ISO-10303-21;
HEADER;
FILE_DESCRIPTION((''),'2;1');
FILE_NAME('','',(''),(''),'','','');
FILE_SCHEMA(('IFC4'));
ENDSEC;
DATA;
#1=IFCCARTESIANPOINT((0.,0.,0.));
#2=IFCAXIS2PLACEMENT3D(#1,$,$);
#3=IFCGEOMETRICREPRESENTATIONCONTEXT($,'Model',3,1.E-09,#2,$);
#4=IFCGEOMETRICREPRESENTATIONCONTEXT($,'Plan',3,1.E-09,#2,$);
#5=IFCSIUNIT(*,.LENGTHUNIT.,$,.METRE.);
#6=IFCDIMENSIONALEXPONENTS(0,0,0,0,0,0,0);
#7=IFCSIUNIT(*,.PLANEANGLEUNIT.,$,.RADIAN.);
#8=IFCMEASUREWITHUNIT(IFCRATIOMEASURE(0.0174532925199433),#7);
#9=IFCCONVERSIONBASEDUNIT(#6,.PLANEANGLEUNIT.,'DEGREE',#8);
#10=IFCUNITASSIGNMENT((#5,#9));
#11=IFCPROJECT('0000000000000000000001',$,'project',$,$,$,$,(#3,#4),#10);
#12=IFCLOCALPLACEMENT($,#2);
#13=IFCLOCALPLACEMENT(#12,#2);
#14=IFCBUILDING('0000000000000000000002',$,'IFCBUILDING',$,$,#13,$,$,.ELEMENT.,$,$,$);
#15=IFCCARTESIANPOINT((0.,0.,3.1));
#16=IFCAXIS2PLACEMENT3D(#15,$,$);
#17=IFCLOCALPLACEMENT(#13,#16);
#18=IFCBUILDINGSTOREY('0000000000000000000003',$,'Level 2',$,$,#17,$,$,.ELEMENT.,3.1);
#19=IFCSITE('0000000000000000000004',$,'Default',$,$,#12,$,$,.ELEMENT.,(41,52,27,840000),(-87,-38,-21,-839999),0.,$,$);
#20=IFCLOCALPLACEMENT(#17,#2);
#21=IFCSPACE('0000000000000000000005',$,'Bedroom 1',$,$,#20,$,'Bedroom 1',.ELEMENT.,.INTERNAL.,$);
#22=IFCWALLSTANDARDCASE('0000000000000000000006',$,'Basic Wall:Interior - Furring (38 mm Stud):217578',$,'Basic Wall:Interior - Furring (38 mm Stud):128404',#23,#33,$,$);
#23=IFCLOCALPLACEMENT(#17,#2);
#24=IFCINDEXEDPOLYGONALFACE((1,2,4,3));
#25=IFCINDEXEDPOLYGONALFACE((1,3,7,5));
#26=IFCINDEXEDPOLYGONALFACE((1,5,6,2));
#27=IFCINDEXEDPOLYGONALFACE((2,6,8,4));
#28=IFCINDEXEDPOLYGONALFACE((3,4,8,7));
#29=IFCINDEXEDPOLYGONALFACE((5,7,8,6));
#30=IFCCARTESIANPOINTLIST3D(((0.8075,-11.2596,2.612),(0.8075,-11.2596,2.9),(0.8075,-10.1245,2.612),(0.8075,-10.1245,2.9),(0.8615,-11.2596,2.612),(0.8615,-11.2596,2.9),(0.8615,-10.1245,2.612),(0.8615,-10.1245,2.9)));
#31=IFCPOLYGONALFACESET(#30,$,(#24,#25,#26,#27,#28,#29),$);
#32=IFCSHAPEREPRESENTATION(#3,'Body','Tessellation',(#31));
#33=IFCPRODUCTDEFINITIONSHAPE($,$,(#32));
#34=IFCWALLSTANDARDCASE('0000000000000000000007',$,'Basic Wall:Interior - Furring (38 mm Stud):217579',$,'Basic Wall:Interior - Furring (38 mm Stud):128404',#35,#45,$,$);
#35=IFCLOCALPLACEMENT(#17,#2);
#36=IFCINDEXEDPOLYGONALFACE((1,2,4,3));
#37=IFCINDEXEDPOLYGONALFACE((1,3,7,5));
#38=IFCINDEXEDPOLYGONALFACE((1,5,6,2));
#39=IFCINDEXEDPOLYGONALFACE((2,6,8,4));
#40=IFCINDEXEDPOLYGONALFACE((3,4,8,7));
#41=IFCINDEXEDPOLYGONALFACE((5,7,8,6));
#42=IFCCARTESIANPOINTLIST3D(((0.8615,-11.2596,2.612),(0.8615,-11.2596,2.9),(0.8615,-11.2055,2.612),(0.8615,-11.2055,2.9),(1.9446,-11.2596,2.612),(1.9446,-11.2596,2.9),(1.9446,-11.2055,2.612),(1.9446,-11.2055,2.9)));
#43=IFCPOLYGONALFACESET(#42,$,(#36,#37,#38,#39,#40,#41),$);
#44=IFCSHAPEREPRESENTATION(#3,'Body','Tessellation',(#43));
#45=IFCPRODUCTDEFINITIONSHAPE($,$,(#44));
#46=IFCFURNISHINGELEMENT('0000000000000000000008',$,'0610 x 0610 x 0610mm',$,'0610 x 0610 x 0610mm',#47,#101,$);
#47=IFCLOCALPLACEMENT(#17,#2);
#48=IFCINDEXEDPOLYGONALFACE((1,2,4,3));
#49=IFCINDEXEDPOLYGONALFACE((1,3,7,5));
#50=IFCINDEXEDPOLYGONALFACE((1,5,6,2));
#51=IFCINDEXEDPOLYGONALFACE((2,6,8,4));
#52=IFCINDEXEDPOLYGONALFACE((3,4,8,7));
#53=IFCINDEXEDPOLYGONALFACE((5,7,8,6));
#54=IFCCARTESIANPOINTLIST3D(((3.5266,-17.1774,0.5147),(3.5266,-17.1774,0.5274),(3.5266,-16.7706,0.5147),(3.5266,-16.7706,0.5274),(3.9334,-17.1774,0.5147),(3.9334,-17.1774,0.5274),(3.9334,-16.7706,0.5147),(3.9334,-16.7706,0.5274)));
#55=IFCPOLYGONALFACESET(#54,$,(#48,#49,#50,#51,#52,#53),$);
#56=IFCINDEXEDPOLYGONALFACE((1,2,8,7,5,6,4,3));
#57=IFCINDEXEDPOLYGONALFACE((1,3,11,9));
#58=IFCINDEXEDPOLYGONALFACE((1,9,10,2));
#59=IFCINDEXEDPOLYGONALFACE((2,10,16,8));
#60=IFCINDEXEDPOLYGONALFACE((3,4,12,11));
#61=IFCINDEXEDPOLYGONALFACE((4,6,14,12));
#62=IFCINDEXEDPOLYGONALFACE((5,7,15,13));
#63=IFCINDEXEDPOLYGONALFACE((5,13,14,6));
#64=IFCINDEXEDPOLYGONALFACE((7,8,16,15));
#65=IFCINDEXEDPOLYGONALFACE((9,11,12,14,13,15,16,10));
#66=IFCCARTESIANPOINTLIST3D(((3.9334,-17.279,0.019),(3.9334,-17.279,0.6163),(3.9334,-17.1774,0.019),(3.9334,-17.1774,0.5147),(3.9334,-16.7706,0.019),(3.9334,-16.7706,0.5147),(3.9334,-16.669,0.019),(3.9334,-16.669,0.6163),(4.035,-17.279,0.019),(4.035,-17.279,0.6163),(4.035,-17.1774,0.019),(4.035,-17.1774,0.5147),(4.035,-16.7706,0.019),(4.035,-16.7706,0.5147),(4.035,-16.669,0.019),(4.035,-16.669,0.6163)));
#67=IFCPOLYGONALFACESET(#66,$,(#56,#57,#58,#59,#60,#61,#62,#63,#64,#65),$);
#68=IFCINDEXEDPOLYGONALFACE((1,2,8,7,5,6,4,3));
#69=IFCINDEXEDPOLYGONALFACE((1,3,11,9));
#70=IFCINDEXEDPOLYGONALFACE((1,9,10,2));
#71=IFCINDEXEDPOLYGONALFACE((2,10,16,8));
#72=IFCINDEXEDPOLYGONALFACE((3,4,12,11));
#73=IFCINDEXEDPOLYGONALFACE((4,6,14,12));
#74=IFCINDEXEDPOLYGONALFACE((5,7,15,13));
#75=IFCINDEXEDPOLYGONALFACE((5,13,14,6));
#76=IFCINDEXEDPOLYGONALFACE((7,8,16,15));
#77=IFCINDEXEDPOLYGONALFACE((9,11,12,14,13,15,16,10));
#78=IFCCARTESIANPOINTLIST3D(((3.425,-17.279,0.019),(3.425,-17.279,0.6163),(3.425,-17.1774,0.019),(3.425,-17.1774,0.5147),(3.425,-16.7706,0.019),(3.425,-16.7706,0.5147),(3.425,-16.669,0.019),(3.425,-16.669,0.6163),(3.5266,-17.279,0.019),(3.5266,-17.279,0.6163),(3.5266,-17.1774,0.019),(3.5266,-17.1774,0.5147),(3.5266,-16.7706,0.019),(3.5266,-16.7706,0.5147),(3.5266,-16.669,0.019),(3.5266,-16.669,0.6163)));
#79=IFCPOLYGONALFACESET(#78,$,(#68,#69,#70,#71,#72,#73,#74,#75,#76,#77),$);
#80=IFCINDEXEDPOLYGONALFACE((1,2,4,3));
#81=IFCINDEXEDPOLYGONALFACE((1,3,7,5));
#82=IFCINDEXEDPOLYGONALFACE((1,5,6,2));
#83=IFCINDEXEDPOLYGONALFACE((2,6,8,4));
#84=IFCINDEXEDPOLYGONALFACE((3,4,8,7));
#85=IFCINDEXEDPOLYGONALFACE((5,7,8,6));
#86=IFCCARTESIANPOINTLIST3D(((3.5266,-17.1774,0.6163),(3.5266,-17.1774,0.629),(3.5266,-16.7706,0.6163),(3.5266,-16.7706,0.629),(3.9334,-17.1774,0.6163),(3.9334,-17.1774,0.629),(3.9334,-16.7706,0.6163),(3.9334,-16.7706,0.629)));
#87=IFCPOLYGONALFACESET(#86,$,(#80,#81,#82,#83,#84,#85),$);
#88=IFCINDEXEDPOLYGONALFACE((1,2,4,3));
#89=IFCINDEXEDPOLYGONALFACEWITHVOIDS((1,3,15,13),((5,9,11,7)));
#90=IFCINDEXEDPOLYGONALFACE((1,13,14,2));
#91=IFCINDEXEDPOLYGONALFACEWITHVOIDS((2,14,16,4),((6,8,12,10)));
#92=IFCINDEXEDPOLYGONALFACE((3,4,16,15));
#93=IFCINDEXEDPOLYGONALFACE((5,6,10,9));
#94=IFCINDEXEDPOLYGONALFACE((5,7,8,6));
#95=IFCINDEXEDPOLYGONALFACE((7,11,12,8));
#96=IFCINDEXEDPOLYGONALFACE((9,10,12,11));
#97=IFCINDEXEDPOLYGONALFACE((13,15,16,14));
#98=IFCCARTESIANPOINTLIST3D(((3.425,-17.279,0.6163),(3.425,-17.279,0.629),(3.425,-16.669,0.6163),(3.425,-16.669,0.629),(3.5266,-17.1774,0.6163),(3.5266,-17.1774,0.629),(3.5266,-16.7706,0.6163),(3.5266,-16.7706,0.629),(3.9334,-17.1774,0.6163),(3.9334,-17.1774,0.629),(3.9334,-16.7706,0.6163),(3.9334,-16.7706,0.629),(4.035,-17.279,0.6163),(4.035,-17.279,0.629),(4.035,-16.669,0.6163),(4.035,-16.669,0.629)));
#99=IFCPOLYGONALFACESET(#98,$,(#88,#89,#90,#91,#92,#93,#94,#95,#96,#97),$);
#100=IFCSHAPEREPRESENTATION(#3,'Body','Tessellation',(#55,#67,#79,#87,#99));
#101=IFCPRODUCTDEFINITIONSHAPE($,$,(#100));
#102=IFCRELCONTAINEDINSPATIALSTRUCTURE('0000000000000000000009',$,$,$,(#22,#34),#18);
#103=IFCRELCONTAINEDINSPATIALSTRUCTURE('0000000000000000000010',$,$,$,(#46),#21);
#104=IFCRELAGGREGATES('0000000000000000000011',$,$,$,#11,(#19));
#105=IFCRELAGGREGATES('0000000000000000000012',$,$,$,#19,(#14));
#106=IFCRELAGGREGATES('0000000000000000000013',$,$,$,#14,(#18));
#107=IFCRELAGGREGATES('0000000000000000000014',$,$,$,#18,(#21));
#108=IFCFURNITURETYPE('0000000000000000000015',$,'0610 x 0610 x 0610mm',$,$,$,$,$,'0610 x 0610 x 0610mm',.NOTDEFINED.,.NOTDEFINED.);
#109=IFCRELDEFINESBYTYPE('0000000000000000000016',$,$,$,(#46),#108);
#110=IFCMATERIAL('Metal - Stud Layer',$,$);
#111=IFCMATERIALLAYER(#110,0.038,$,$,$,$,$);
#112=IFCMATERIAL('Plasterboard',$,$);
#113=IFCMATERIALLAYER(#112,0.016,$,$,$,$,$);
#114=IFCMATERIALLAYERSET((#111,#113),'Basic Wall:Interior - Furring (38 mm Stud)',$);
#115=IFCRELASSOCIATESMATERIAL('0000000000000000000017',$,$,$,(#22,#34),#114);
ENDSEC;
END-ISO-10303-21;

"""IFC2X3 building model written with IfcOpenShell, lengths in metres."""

from ifc_helpers import new_model, entity, si_unit, converted_unit, frame, frame_2d, origin, origin_2d_with_axis, place, context, project, spatial, polyline, rectangle, outline, extrude, source, transform, mapped, material, layer, layer_set, layer_usage, type_object, type_shapes, element, save


model = new_model("IFC2X3")

# Units and contexts
model_context = context("Model", 3, precision=1e-09, world=origin())
plan_context = context("Plan", 3, precision=1e-09, world=origin())
ifc_project = project(units=[si_unit("LENGTHUNIT", "METRE"), converted_unit("PLANEANGLEUNIT", "DEGREE", entity("IfcRatioMeasure", 0.0174532925199433), si_unit("PLANEANGLEUNIT", "RADIAN"), dimensions=[0, 0, 0, 0, 0, 0, 0])], contexts=[model_context, plan_context])

# Site, building, storey
site_placement = place(None, origin())
site = spatial("IfcSite", under=ifc_project, at=site_placement, Name="Default", CompositionType="ELEMENT", RefLatitude=(41, 52, 27, 840000), RefLongitude=(-87, -38, -21, -839999), RefElevation=0.0)
building_placement = place(site_placement, origin())
building = spatial("IfcBuilding", under=site, at=building_placement, Name="IFCBUILDING", CompositionType="ELEMENT")
storey_placement = place(building_placement, frame((0.0, 0.0, 3.1)))
storey = spatial("IfcBuildingStorey", under=building, at=storey_placement, Name="Level 2", CompositionType="ELEMENT", Elevation=3.1)

# Shared definitions
ifc_material_1 = material(Name="Metal - Stud Layer")
ifc_material_2 = material(Name="Plasterboard")

# Walls
ifc_layer_1 = layer(ifc_material_1, 0.038)
ifc_layer_2 = layer(ifc_material_2, 0.016)
ifc_layer_set_1 = layer_set([ifc_layer_1, ifc_layer_2], Name="Basic Wall:Interior - Furring (38 mm Stud)")
ifc_layer_usage_1 = layer_usage(ifc_layer_set_1, "AXIS2", "NEGATIVE", 0.027)
wall_1_placement = place(storey_placement, frame((0.8345, -11.2596, 2.612), z_axis=(0.0, 0.0, 1.0), x_axis=(0.0, 1.0, 0.0)))
element("IfcWallStandardCase", 1, at=wall_1_placement, inside=storey, material=ifc_layer_usage_1, Name="Basic Wall:Interior - Furring (38 mm Stud):217578", ObjectType="Basic Wall:Interior - Furring (38 mm Stud):128404", context=model_context, shape_type="SweptSolid", body=[
    extrude(rectangle(XDim=1.1351, YDim=0.054, at=frame_2d((0.5675, 0.0), x_axis=(-1.0, 0.0))), origin(), (0.0, 0.0, 1.0), 0.288),
])
ifc_layer_usage_2 = layer_usage(ifc_layer_set_1, "AXIS2", "NEGATIVE", 0.027)
wall_2_placement = place(storey_placement, frame((1.9446, -11.2325, 2.612), z_axis=(0.0, 0.0, 1.0), x_axis=(-1.0, 0.0, 0.0)))
element("IfcWallStandardCase", 2, at=wall_2_placement, inside=storey, material=ifc_layer_usage_2, Name="Basic Wall:Interior - Furring (38 mm Stud):217579", ObjectType="Basic Wall:Interior - Furring (38 mm Stud):128404", context=model_context, shape_type="SweptSolid", body=[
    extrude(rectangle(XDim=1.0831, YDim=0.054, at=frame_2d((0.5415, 0.0), x_axis=(-1.0, 0.0))), origin(), (0.0, 0.0, 1.0), 0.288),
])

# Shared definitions
space_placement = place(storey_placement, origin())
space = spatial("IfcSpace", under=storey, at=space_placement, Name="Bedroom 1", LongName="Bedroom 1", CompositionType="ELEMENT", InteriorOrExteriorSpace="INTERNAL")

# Furnishing element
furniture_type = type_object("IfcFurnitureType", Name="0610 x 0610 x 0610mm", ElementType="0610 x 0610 x 0610mm", AssemblyPlace="NOTDEFINED")
shared_shape_1 = source(origin(), model_context, "Body", "SweptSolid", [
    extrude(rectangle(XDim=0.4068, YDim=0.4068, at=origin_2d_with_axis()), frame((0.0183, 0.0952, 0.4957), z_axis=(0.0, 0.0, 1.0), x_axis=(-1.0, 0.0, 0.0)), (0.0, 0.0, 1.0), 0.0127),
    extrude(outline(polyline([(-0.2732, -0.305), (0.324, -0.305), (0.324, 0.305), (-0.2732, 0.305), (-0.2732, 0.2034), (0.2225, 0.2034), (0.2225, -0.2034), (-0.2732, -0.2034), (-0.2732, -0.305)])), frame((0.2217, 0.0952, 0.2732), z_axis=(1.0, 0.0, 0.0), x_axis=(0.0, 0.0, 1.0)), (0.0, 0.0, 1.0), 0.1016),
    extrude(outline(polyline([(-0.305, -0.3241), (0.305, -0.3241), (0.305, 0.2733), (0.2034, 0.2733), (0.2034, -0.2224), (-0.2034, -0.2224), (-0.2034, 0.2733), (-0.305, 0.2733), (-0.305, -0.3241)])), frame((-0.2867, 0.0952, 0.2733), z_axis=(1.0, 0.0, 0.0), x_axis=(0.0, -1.0, 0.0)), (0.0, 0.0, 1.0), 0.1016),
    extrude(rectangle(XDim=0.4068, YDim=0.4068, at=origin_2d_with_axis()), frame((0.0183, 0.0952, 0.5973), z_axis=(0.0, 0.0, 1.0), x_axis=(-1.0, 0.0, 0.0)), (0.0, 0.0, 1.0), 0.0127),
    extrude(outline(polyline([(-0.305, -0.305), (0.305, -0.305), (0.305, 0.305), (-0.305, 0.305), (-0.305, -0.305)]), holes=[polyline([(-0.2034, -0.2034), (-0.2034, 0.2034), (0.2034, 0.2034), (0.2034, -0.2034), (-0.2034, -0.2034)])]), frame((0.0183, 0.0952, 0.5973), z_axis=(0.0, 0.0, 1.0), x_axis=(-1.0, 0.0, 0.0)), (0.0, 0.0, 1.0), 0.0127),
])
type_shapes(furniture_type, [shared_shape_1])
furnishing_placement = place(space_placement, frame((3.7117, -17.0692, 0.019)))
element("IfcFurnishingElement", 3, at=furnishing_placement, inside=space, type_object=furniture_type, Name="0610 x 0610 x 0610mm", ObjectType="0610 x 0610 x 0610mm", context=model_context, shape_type="MappedRepresentation", body=[
    mapped(shared_shape_1, transform((0.0, 0.0, 0.0), scale=1.0)),
])

save(model, "model.ifc")
